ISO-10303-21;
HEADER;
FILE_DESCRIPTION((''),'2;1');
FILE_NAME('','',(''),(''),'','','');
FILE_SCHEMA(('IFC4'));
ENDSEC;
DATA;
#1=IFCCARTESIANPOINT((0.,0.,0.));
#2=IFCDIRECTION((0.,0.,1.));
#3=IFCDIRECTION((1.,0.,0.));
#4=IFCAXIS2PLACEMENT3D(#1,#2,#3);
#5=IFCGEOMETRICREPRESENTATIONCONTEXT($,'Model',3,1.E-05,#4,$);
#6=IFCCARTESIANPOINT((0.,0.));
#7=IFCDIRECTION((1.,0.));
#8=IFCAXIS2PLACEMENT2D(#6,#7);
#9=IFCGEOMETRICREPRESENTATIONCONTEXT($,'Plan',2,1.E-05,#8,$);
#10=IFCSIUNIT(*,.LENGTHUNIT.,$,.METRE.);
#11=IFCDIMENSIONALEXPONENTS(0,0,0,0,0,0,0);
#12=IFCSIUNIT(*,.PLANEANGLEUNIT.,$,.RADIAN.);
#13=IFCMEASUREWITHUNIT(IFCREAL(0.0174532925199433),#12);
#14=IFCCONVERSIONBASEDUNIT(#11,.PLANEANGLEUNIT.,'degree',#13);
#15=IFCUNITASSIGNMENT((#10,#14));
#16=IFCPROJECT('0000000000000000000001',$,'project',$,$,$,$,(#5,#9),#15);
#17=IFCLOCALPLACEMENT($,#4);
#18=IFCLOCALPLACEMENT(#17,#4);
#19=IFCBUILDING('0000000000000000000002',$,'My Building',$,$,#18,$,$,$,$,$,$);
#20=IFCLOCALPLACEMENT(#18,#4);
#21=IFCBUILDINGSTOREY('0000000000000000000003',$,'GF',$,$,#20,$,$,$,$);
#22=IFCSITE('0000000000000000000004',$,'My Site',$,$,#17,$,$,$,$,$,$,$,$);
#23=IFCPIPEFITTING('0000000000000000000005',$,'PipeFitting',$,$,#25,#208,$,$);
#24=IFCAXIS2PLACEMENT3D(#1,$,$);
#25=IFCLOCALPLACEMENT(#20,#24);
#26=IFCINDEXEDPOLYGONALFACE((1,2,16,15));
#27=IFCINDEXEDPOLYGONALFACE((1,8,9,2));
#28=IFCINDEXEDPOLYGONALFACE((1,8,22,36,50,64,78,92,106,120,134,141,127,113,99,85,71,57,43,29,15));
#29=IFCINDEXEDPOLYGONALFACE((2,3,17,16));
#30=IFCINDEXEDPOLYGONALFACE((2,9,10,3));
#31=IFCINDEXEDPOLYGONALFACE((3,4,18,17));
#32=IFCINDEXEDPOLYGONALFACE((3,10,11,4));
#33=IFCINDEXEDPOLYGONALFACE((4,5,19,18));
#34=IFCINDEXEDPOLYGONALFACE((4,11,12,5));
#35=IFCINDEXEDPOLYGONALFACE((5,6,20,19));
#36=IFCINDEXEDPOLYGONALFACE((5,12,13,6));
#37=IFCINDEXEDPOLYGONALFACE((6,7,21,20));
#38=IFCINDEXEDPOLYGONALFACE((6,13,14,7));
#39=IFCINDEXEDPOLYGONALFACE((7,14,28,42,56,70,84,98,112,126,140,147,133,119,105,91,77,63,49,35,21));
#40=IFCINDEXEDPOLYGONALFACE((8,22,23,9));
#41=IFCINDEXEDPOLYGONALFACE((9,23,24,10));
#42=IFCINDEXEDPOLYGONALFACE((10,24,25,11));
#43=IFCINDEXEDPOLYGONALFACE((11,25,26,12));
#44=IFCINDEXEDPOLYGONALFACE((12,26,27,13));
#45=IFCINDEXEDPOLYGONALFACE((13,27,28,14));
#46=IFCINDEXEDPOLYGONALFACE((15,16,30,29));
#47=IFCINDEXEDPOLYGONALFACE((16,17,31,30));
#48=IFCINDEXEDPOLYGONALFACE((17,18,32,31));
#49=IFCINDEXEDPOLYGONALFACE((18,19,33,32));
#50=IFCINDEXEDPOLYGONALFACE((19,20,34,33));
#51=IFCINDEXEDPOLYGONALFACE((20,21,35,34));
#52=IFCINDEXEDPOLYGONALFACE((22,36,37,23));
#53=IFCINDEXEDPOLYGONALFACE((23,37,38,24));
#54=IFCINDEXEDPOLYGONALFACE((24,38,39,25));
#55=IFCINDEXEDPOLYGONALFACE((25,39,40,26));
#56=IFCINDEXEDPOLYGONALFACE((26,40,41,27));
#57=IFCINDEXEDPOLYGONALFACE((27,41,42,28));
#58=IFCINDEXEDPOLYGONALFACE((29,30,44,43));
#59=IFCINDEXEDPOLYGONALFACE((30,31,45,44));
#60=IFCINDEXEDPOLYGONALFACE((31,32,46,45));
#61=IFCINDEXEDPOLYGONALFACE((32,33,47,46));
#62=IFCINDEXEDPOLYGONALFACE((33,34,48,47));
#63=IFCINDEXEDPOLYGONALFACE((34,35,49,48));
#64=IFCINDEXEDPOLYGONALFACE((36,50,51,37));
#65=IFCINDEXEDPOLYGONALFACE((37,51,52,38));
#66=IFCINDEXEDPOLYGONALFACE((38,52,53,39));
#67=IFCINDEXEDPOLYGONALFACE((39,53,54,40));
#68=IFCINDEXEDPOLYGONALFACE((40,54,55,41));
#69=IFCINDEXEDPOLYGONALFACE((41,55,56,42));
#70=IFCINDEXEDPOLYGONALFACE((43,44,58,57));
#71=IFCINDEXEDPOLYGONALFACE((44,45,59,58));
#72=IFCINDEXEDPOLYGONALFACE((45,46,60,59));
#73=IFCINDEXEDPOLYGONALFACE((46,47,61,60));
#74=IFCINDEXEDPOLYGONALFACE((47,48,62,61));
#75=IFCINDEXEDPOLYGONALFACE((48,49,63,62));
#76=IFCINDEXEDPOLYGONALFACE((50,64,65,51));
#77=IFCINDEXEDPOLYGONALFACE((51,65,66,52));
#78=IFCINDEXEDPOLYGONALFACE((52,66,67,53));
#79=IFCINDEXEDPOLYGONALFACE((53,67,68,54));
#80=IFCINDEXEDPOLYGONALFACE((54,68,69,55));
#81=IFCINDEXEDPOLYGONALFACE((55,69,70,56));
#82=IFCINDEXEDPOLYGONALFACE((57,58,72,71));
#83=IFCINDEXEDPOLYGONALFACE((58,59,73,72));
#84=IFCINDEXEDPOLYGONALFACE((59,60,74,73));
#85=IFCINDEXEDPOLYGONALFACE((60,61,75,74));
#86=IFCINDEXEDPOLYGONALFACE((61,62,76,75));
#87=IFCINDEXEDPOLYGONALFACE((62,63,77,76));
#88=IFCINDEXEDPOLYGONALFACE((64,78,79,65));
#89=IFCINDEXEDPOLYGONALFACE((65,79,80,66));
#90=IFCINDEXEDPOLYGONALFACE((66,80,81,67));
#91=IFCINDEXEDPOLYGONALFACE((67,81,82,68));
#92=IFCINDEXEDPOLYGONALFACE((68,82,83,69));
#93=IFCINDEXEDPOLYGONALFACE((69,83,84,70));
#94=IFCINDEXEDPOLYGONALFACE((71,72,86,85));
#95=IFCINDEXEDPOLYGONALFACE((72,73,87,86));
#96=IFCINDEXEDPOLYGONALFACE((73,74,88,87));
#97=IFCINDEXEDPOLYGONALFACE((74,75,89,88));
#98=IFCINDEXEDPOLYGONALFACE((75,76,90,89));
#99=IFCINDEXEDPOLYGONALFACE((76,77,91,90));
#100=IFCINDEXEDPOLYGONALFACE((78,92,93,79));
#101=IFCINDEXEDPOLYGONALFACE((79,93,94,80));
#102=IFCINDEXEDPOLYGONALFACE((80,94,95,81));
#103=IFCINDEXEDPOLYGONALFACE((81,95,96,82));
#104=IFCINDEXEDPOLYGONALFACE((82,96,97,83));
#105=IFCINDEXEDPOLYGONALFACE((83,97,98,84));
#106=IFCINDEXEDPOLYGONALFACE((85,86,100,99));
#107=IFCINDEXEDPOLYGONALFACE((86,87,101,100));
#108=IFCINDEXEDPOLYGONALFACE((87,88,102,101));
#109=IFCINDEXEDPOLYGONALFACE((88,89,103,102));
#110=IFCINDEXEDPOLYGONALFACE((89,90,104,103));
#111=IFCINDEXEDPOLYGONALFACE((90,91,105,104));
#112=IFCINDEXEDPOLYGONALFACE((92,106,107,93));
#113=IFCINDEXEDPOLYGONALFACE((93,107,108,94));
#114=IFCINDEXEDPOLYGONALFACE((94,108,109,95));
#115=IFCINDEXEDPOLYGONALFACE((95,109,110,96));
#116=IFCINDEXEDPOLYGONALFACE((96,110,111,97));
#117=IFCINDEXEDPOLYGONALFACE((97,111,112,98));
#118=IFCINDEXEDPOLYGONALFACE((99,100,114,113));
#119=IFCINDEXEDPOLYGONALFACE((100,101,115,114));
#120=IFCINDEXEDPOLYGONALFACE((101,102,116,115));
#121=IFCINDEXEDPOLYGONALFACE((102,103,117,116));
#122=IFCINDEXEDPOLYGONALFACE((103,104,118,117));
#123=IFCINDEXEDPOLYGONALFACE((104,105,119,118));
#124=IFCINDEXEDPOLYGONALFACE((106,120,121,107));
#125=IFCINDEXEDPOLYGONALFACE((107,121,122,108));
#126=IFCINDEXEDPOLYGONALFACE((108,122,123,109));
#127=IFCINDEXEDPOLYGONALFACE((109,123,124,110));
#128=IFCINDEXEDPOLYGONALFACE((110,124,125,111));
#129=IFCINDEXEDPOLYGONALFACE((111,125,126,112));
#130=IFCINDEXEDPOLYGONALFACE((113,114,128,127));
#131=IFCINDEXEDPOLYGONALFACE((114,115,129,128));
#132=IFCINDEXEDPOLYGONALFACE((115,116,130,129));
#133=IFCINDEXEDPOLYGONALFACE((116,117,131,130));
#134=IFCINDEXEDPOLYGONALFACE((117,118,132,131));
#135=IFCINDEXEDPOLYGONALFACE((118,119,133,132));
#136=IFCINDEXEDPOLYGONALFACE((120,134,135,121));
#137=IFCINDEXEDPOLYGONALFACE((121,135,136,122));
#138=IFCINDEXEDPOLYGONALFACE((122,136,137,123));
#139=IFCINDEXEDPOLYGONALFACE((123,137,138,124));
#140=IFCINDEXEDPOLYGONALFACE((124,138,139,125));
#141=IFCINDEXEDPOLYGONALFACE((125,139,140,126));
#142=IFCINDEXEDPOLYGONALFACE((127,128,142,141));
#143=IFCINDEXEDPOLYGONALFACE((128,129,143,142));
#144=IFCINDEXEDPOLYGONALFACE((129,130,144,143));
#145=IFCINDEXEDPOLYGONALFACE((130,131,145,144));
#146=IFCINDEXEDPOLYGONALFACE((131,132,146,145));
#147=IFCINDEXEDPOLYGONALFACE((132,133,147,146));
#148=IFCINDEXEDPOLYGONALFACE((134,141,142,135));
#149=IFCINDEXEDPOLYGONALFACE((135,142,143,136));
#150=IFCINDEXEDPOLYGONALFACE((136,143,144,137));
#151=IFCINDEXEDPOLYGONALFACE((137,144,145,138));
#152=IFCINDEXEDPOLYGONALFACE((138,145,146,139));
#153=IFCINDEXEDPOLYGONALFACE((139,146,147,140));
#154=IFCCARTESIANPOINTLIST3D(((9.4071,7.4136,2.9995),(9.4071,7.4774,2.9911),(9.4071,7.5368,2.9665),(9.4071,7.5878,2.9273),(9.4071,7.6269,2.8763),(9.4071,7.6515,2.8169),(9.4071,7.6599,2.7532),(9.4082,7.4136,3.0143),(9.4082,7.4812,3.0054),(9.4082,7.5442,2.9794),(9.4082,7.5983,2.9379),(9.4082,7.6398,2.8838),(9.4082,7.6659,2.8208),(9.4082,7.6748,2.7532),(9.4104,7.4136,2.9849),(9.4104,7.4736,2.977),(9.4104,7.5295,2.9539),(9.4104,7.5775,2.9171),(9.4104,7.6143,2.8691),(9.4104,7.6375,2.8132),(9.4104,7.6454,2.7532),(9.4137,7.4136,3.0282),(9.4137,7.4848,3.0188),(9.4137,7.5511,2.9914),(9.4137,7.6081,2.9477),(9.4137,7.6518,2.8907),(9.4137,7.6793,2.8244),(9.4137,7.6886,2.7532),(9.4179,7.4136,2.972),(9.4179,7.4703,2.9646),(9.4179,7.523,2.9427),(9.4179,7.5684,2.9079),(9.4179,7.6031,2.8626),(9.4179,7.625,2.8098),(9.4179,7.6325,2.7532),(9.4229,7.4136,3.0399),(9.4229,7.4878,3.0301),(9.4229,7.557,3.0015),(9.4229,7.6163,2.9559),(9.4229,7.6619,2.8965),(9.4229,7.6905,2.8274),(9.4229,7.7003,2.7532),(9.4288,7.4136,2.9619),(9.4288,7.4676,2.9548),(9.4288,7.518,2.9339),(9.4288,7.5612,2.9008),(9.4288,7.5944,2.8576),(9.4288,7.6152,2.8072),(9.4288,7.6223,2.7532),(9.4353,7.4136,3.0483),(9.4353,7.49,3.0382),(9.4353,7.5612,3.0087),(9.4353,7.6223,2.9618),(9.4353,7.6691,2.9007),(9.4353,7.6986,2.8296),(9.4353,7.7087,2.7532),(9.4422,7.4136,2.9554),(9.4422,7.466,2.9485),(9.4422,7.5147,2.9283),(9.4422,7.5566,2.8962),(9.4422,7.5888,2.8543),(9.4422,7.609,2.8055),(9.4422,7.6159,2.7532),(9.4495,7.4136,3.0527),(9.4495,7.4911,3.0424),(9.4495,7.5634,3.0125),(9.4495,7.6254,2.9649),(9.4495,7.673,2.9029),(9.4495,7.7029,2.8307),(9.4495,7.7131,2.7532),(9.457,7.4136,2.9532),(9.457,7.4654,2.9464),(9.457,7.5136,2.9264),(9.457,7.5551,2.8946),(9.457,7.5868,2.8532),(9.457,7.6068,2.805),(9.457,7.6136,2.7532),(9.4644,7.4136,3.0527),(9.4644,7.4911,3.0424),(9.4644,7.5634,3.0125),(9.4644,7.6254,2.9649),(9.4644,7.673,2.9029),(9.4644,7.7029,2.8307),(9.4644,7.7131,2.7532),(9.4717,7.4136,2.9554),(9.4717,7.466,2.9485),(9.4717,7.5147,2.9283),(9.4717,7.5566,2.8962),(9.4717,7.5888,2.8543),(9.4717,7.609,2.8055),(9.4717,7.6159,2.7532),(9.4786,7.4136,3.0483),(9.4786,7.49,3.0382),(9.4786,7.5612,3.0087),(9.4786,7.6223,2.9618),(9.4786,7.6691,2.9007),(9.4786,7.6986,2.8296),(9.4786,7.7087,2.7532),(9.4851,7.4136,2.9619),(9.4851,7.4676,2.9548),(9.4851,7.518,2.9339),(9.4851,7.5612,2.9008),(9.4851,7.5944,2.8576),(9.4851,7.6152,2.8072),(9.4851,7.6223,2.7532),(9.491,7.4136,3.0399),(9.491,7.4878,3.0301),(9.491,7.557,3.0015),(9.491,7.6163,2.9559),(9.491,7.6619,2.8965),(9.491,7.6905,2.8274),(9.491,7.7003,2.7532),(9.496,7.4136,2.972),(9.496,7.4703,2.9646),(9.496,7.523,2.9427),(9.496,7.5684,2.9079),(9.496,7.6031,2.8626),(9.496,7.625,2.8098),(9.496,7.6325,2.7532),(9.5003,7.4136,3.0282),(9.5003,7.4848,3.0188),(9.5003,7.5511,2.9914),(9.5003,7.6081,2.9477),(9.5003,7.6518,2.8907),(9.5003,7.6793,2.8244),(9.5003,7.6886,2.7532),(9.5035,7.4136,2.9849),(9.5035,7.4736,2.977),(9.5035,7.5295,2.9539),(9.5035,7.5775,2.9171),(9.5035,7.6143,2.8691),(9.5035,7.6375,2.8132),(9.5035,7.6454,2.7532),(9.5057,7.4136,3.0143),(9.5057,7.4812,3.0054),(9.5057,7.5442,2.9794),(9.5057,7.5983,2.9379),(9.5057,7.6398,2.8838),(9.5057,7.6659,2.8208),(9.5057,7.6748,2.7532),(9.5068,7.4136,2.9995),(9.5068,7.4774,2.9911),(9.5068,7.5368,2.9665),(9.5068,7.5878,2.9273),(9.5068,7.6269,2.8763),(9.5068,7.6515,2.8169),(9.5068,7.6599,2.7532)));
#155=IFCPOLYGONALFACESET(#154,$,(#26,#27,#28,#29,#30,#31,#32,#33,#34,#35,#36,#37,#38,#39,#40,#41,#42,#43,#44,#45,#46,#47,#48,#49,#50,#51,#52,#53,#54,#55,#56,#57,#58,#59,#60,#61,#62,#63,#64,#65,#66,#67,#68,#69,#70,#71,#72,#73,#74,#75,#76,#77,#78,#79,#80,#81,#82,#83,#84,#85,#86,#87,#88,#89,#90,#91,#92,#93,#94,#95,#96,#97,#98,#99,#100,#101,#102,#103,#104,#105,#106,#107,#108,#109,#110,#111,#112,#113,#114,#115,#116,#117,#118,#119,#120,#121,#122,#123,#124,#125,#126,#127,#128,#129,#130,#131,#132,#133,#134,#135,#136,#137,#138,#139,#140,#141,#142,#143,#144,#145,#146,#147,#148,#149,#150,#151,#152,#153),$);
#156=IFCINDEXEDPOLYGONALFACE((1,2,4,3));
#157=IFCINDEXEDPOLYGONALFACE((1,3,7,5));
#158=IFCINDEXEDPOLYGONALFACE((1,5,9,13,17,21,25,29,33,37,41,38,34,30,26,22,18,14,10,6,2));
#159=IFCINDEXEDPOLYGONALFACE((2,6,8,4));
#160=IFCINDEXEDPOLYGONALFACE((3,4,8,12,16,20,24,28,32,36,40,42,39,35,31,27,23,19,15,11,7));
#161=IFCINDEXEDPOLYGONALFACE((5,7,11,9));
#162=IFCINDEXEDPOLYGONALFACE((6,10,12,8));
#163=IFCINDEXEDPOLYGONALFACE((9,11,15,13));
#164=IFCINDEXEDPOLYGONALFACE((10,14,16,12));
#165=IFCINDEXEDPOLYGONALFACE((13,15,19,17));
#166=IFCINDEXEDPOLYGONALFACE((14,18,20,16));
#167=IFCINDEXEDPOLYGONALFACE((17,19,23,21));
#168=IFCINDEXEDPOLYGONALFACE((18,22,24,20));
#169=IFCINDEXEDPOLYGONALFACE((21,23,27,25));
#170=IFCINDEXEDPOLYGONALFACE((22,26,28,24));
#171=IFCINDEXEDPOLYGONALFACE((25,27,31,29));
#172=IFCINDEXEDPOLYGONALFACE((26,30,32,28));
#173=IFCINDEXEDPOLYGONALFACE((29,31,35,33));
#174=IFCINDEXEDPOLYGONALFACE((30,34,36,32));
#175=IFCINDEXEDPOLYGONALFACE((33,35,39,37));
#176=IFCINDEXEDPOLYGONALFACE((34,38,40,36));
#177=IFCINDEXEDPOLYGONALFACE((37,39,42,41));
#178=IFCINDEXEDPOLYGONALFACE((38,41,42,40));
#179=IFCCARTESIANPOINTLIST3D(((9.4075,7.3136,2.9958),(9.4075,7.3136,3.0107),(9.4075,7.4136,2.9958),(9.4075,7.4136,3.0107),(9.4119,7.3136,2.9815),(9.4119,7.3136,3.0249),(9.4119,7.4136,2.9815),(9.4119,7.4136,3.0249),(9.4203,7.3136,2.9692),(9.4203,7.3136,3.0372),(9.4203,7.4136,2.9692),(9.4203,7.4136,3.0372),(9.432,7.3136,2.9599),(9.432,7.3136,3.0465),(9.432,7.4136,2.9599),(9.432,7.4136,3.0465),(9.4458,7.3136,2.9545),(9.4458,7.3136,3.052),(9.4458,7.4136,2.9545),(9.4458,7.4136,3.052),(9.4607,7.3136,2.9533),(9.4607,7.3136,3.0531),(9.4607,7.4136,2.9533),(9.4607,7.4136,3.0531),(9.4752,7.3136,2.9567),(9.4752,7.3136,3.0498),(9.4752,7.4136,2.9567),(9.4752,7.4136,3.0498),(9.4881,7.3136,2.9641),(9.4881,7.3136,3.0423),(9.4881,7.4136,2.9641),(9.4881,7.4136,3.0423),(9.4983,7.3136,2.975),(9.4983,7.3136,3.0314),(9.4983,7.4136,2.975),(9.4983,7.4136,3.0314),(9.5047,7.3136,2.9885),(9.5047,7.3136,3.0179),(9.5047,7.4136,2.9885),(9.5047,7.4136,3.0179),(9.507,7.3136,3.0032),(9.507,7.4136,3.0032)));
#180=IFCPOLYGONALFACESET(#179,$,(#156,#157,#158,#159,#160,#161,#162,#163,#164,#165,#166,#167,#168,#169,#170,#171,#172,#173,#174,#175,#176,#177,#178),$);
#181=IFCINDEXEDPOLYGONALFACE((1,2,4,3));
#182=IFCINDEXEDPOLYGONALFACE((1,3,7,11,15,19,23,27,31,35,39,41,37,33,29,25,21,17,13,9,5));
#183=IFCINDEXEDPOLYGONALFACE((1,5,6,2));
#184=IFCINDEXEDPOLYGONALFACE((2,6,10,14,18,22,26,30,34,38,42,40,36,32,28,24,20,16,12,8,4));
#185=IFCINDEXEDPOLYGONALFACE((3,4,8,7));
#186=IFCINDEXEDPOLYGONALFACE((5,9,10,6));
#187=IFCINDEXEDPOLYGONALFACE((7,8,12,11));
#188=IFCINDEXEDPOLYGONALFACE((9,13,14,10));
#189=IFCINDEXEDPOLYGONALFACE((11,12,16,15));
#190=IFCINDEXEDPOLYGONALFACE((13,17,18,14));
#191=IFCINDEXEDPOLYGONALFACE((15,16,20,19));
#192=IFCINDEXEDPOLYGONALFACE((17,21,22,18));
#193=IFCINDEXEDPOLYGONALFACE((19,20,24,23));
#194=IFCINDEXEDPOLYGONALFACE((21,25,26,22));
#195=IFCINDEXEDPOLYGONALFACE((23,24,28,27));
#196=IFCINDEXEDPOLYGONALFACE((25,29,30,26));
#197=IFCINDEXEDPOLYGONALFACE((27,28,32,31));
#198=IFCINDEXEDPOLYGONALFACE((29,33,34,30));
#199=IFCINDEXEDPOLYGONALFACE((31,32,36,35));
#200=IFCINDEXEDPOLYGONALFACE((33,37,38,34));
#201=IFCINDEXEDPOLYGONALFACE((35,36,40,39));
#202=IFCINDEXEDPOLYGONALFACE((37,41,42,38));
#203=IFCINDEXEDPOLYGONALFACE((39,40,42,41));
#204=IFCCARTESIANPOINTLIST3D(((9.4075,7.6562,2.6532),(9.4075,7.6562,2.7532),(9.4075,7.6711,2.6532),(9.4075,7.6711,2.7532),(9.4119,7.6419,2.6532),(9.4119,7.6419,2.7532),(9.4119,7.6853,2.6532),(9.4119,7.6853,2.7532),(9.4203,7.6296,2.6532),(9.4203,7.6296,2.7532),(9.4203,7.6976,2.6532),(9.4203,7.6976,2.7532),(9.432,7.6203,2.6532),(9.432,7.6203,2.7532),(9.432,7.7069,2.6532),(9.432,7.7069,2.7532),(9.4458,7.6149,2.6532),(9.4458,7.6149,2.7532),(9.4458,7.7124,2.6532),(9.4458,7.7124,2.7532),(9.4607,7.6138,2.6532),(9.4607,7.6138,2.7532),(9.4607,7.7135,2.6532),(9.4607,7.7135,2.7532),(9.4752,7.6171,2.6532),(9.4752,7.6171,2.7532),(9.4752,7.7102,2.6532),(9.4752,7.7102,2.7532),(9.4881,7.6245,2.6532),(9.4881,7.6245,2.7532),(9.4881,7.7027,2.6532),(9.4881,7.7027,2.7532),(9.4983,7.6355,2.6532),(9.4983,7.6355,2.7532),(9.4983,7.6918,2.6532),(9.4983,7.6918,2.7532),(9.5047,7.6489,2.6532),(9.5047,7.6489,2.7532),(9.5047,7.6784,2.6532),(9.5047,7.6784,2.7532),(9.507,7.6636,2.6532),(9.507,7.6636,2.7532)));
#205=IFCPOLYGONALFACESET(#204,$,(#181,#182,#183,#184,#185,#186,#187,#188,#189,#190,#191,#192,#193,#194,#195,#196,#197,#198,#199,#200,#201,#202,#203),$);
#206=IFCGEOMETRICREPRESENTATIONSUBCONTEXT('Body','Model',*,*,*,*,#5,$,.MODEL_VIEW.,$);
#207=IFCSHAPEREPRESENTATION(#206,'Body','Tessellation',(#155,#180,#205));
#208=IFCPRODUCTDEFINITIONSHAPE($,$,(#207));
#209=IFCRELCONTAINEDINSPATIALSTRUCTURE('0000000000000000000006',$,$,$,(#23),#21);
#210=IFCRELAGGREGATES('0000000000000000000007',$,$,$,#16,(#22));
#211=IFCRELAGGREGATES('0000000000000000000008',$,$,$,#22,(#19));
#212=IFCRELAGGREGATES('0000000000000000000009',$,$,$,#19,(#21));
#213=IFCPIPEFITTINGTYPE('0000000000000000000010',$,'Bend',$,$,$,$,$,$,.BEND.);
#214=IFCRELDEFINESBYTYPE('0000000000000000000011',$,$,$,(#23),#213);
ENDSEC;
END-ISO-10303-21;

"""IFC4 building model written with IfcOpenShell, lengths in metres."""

from ifc_helpers import new_model, entity, si_unit, converted_unit, frame, origin_with_axes, origin_2d_with_axis, place, context, subcontext, project, spatial, circle, extrude, source, transform, mapped, type_object, type_shapes, element, save


model = new_model("IFC4")

# Units and contexts
model_context = context("Model", 3, precision=1e-05, world=origin_with_axes())
plan_context = context("Plan", 2, precision=1e-05, world=origin_2d_with_axis())
body_context_1 = subcontext(model_context, "Body", "Model", "MODEL_VIEW")
ifc_project = project(units=[si_unit("LENGTHUNIT", "METRE"), converted_unit("PLANEANGLEUNIT", "degree", entity("IfcReal", 0.0174532925199433), si_unit("PLANEANGLEUNIT", "RADIAN"), dimensions=[0, 0, 0, 0, 0, 0, 0])], contexts=[model_context, plan_context])

# Site, building, storey
site_placement = place(None, origin_with_axes())
site = spatial("IfcSite", under=ifc_project, at=site_placement, Name="My Site")
building_placement = place(site_placement, origin_with_axes())
building = spatial("IfcBuilding", under=site, at=building_placement, Name="My Building")
storey_placement = place(building_placement, origin_with_axes())
storey = spatial("IfcBuildingStorey", under=building, at=storey_placement, Name="GF")

# Shared definitions
pipe_fitting_type = type_object("IfcPipeFittingType", Name="Bend", PredefinedType="BEND")
shared_shape_1 = source(origin_with_axes(), body_context_1, "Body", "SolidModel", [
    entity("IfcSweptDiskSolid", entity("IfcIndexedPolyCurve", entity("IfcCartesianPointList3D", [[0.0, 0.0, -0.1], [0.0, -0.0732, -0.2768], [0.0, -0.25, -0.35]]), [entity("IfcArcIndex", [1, 2, 3])]), 0.05),
    extrude(circle(Radius=0.05), origin_with_axes(), (0.0, 0.0, -1.0), 0.1),
    extrude(circle(Radius=0.05), frame((0.0, -0.25, -0.35), z_axis=(0.0, -1.0, 0.0), x_axis=(1.0, 0.0, 0.0)), (0.0, 0.0, 1.0), 0.1),
])
type_shapes(pipe_fitting_type, [shared_shape_1])

# Pipe fitting
for number, where, z_axis, x_axis, name in (
    (1, (9.457, 7.3136, 3.0032), (0.0, -1.0, 0.0), (1.0, 0.0, 0.0), "PipeFitting"),
):
    element("IfcPipeFitting", number, at=place(storey_placement, frame(where, z_axis=z_axis, x_axis=x_axis)), inside=storey, type_object=pipe_fitting_type, Name=name, context=body_context_1, shape_type="MappedRepresentation", body=[
        mapped(shared_shape_1, transform((0.0, 0.0, 0.0), x_axis=(1.0, 0.0, 0.0), y_axis=(0.0, 1.0, 0.0), z_axis=(0.0, 0.0, 1.0), scale=1.0)),
    ])

save(model, "model.ifc")
